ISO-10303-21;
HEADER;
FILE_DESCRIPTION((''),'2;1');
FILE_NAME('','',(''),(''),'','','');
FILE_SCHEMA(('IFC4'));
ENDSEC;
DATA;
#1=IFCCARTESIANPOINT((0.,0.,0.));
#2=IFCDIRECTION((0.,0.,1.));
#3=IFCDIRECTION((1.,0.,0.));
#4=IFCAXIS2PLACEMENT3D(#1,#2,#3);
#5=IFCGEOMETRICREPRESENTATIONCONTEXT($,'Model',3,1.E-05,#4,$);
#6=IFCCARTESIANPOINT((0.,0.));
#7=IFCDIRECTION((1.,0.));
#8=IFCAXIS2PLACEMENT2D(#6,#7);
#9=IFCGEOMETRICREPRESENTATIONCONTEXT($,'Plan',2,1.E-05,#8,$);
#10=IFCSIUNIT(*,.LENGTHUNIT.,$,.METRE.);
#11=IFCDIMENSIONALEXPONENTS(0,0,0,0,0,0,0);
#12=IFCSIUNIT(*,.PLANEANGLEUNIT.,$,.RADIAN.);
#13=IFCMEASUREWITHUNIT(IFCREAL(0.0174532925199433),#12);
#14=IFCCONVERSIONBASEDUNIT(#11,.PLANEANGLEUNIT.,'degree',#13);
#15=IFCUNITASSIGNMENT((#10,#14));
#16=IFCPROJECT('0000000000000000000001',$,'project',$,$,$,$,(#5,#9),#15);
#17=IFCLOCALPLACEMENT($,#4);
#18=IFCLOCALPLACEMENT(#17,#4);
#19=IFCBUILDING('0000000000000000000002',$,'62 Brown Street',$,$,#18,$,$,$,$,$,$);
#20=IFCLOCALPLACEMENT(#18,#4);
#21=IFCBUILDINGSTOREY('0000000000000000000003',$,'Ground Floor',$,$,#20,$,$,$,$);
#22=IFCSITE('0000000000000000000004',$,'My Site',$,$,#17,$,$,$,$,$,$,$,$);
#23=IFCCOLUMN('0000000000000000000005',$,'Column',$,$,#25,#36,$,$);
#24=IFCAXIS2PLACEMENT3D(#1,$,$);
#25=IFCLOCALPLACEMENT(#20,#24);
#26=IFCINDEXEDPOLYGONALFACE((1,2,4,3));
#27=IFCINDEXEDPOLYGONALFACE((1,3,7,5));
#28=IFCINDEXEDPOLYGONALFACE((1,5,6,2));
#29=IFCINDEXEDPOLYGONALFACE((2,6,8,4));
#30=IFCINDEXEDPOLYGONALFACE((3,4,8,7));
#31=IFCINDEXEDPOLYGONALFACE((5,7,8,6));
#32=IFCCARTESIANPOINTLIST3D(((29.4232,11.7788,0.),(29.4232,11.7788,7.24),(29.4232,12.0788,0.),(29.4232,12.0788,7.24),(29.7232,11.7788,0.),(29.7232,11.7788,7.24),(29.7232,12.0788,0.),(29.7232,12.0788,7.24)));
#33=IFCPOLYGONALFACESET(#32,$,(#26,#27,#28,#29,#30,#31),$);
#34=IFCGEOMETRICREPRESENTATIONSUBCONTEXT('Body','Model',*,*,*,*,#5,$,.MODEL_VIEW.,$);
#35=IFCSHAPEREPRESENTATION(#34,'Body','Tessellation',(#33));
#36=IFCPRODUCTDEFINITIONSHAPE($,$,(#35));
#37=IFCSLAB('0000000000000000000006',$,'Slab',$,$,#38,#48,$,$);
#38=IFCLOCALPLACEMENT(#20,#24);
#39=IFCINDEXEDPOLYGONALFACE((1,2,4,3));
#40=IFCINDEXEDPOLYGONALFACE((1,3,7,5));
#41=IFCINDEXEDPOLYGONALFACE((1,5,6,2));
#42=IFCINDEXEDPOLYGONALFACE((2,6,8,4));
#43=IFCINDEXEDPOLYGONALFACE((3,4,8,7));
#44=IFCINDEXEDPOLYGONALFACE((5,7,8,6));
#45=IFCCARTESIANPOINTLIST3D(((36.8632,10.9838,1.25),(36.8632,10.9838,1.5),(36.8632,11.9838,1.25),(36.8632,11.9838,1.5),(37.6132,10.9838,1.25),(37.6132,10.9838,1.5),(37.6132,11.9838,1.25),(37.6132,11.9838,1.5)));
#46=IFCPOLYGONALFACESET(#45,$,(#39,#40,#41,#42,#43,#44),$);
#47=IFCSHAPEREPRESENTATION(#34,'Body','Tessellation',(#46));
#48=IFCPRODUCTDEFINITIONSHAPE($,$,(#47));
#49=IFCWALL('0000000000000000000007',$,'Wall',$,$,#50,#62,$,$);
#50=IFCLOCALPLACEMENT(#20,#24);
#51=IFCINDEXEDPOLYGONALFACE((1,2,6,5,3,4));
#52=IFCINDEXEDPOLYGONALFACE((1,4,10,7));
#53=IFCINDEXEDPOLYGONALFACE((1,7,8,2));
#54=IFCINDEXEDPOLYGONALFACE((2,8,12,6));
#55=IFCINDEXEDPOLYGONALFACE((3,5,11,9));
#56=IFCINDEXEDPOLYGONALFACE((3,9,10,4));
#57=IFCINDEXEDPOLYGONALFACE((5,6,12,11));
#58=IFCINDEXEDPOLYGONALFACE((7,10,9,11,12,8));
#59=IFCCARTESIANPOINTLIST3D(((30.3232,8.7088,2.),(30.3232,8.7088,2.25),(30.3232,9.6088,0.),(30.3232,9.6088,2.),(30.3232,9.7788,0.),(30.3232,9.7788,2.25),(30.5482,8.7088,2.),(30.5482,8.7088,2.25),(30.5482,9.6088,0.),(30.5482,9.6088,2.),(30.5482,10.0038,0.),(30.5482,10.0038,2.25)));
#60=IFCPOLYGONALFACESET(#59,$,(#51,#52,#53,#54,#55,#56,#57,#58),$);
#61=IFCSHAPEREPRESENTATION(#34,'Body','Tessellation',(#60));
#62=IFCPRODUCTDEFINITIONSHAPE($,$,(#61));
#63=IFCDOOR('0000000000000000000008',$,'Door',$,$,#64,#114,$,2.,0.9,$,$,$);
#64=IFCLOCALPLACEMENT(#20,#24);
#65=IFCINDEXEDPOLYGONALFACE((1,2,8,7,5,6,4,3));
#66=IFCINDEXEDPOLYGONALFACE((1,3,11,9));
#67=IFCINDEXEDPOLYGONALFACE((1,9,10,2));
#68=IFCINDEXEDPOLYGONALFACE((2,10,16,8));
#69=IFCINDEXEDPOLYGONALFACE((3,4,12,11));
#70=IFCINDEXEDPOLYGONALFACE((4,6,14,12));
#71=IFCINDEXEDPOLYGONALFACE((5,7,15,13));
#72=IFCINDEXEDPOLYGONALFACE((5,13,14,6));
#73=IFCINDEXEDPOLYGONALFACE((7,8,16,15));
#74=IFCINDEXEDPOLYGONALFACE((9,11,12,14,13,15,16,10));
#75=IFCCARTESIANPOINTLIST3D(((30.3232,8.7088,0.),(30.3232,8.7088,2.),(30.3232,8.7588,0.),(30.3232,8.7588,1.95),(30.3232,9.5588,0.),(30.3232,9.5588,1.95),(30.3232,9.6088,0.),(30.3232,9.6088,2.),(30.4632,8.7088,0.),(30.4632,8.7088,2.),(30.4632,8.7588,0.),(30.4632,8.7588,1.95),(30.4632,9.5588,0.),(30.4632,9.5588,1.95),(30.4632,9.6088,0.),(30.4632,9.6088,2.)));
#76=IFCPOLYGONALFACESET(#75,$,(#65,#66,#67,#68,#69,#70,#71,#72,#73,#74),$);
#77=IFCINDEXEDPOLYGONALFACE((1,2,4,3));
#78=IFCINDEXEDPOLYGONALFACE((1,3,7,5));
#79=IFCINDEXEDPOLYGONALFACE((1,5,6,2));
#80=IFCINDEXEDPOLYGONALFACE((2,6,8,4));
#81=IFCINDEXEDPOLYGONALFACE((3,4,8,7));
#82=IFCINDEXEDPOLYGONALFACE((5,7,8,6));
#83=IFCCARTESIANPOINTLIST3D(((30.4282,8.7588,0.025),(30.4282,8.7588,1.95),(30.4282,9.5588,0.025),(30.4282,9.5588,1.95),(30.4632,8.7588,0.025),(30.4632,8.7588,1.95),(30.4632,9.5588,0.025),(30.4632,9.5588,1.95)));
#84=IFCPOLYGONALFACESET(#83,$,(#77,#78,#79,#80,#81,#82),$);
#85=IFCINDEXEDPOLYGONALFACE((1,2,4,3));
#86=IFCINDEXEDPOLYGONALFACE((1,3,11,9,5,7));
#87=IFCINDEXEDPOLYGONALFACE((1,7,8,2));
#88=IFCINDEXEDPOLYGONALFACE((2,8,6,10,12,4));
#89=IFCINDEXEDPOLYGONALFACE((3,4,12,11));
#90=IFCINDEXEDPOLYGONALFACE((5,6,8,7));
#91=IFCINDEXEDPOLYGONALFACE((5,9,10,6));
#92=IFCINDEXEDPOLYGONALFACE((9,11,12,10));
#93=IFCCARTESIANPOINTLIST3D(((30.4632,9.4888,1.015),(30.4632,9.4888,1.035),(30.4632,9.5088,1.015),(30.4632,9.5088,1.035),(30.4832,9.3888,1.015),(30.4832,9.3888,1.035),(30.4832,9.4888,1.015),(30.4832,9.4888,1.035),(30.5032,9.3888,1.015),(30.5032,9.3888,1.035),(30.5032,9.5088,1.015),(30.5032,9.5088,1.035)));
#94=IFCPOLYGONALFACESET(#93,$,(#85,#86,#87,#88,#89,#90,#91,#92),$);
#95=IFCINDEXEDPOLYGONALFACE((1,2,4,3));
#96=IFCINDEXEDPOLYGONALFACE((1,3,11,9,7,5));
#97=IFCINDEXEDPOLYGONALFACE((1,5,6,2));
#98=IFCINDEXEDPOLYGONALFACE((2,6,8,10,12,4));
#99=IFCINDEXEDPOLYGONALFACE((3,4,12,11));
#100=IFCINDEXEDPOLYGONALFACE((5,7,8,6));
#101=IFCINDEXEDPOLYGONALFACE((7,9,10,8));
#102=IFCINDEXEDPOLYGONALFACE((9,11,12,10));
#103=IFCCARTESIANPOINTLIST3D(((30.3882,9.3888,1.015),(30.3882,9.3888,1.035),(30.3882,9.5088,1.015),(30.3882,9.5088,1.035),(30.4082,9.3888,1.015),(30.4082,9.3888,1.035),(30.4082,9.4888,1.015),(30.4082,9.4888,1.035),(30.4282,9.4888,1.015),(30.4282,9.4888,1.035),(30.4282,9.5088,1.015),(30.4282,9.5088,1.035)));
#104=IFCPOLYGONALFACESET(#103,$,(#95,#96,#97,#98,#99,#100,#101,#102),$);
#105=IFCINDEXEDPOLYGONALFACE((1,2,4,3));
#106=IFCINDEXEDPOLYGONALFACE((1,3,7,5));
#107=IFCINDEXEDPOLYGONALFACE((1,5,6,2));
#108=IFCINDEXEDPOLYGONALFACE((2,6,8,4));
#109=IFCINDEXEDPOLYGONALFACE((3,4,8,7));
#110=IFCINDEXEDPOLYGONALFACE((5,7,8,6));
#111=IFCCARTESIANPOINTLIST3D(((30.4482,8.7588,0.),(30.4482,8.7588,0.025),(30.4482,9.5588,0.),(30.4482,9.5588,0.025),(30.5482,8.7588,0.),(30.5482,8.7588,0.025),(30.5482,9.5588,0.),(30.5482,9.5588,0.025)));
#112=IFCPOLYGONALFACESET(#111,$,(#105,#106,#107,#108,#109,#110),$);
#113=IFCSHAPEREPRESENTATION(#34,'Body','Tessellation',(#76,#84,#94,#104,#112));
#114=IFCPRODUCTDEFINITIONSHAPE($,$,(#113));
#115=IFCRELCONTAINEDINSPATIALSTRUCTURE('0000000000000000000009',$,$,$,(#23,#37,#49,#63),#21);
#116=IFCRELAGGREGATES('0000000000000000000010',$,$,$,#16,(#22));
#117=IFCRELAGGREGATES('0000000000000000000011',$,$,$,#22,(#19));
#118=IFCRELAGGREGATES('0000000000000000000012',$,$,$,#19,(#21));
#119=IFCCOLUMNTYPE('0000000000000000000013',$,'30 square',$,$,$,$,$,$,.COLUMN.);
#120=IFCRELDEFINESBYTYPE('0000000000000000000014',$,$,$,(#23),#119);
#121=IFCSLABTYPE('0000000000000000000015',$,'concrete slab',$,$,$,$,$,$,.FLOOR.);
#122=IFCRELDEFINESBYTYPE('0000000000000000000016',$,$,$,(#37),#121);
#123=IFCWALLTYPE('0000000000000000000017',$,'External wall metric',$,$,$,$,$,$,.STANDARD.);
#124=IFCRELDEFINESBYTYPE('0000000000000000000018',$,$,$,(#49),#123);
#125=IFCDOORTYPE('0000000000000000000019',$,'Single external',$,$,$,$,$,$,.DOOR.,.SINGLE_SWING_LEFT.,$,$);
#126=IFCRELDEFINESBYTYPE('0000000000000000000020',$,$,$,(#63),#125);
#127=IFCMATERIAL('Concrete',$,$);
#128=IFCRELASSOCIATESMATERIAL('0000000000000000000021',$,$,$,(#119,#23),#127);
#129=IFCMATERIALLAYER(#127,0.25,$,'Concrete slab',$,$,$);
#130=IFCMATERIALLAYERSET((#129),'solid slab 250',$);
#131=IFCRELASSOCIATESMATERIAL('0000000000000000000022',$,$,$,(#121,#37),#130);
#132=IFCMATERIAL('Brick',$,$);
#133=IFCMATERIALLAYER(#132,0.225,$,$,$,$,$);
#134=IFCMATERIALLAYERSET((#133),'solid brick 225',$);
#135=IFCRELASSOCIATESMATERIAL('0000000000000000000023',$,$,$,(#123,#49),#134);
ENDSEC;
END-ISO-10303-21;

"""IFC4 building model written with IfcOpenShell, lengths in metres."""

from ifc_helpers import new_model, entity, si_unit, converted_unit, frame, origin_with_axes, origin_2d_with_axis, place, context, subcontext, project, spatial, line, indexed_curve, rectangle, outline, extrude, clip, halfspace, shape, source, transform, mapped, material, layer, layer_set, layer_usage, material_profile, profile_set, profile_usage, type_object, type_shapes, element, fill, save


model = new_model("IFC4")

# Units and contexts
model_context = context("Model", 3, precision=1e-05, world=origin_with_axes())
plan_context = context("Plan", 2, precision=1e-05, world=origin_2d_with_axis())
body_context_1 = subcontext(model_context, "Body", "Model", "MODEL_VIEW")
body_context_2 = subcontext(plan_context, "Body", "Plan", "PLAN_VIEW")
ifc_project = project(units=[si_unit("LENGTHUNIT", "METRE"), converted_unit("PLANEANGLEUNIT", "degree", entity("IfcReal", 0.0174532925199433), si_unit("PLANEANGLEUNIT", "RADIAN"), dimensions=[0, 0, 0, 0, 0, 0, 0])], contexts=[model_context, plan_context])

# Site, building, storey
site_placement = place(None, origin_with_axes())
site = spatial("IfcSite", under=ifc_project, at=site_placement, Name="My Site")
building_placement = place(site_placement, origin_with_axes())
building = spatial("IfcBuilding", under=site, at=building_placement, Name="62 Brown Street")
storey_placement = place(building_placement, origin_with_axes())
storey = spatial("IfcBuildingStorey", under=building, at=storey_placement, Name="Ground Floor")

# Column
ifc_material_1 = material(Name="Concrete")
ifc_material_profile = material_profile(ifc_material_1, rectangle(XDim=0.3, YDim=0.3))
ifc_profile_set = profile_set([ifc_material_profile])
ifc_profile_usage = profile_usage(ifc_profile_set, cardinal=5)
column_type = type_object("IfcColumnType", Name="30 square", PredefinedType="COLUMN", material=ifc_profile_set)
column_placement = place(storey_placement, frame((29.5732, 11.9288, 0.0), z_axis=(0.0, 0.0, 1.0), x_axis=(1.0, 0.0, 0.0)))
element("IfcColumn", 1, at=column_placement, inside=storey, type_object=column_type, material=ifc_profile_usage, Name="Column", context=body_context_1, shape_type="SweptSolid", body=[
    extrude(rectangle(XDim=0.3, YDim=0.3), origin_with_axes(), (0.0, 0.0, 1.0), 7.24),
])

# Slab
ifc_layer_1 = layer(ifc_material_1, 0.25, Name="Concrete slab")
ifc_layer_set_1 = layer_set([ifc_layer_1], Name="solid slab 250")
slab_type = type_object("IfcSlabType", Name="concrete slab", PredefinedType="FLOOR", material=ifc_layer_set_1)
ifc_layer_usage_1 = layer_usage(ifc_layer_set_1, "AXIS3", "POSITIVE", 0.0)
slab_1_placement = place(storey_placement, frame((36.8632, 10.9838, 1.25), z_axis=(0.0, 0.0, 1.0), x_axis=(1.0, 0.0, 0.0)))
element("IfcSlab", 2, at=slab_1_placement, inside=storey, type_object=slab_type, material=ifc_layer_usage_1, Name="Slab", context=body_context_1, shape_type="SweptSolid", body=[
    extrude(outline(indexed_curve([(0.0, 0.0), (0.75, 0.0), (0.75, 1.0), (0.0, 1.0)], segments=[line(4, 1), line(1, 2), line(2, 3), line(3, 4)], self_intersect=False)), None, (0.0, 0.0, 1.0), 0.25),
])

# Shared definitions
ifc_material_2 = material(Name="Brick")
ifc_layer_2 = layer(ifc_material_2, 0.225)
ifc_layer_set_2 = layer_set([ifc_layer_2], Name="solid brick 225")
wall_type_1 = type_object("IfcWallType", Name="External wall metric", PredefinedType="STANDARD", material=ifc_layer_set_2)

# Wall, opening, door
ifc_layer_usage_2 = layer_usage(ifc_layer_set_2, "AXIS2", "POSITIVE", 0.0)
wall_1_placement = place(storey_placement, frame((30.5482, 8.7088, 0.0), z_axis=(0.0, 0.0, 1.0), x_axis=(0.0, 1.0, 0.0)))
wall_1 = element("IfcWall", 3, at=wall_1_placement, inside=storey, type_object=wall_type_1, material=ifc_layer_usage_2, Name="Wall", context=body_context_1, shape_type="Clipping", body=[
    clip(extrude(outline(indexed_curve([(0.0, 0.0), (0.0, 0.225), (1.295, 0.225), (1.295, 0.0), (0.0, 0.0)], self_intersect=False)), origin_with_axes(), (0.0, 0.0, 1.0), 2.25), halfspace(frame((1.295, 0.0, 0.0), z_axis=(0.506251, 0.506251, 0.0), x_axis=(-0.225, 0.225, 0.0)), False)),
])
shared_shape_1 = source(origin_with_axes(), body_context_1, "Body", "SweptSolid", [
    extrude(outline(indexed_curve([(0.0, 0.0), (0.9, 0.0), (0.9, 2.0), (0.0, 2.0)], segments=[line(1, 2, 3, 4, 1)])), frame((0.0, -0.6, 0.0), z_axis=(0.0, -1.0, 0.0), x_axis=(1.0, 0.0, 0.0)), (0.0, 0.0, -1.0), 1.2),
])
opening_1_placement = place(wall_1_placement, frame((0.0, 0.0, 0.0), z_axis=(0.0, 0.0, 1.0), x_axis=(1.0, 0.0, 0.0)))
opening_1 = element("IfcOpeningElement", 4, at=opening_1_placement, cuts=wall_1, PredefinedType="OPENING", context=body_context_1, shape_type="MappedRepresentation", body=[
    mapped(shared_shape_1, transform((0.0, 0.0, 0.0), x_axis=(1.0, 0.0, 0.0), y_axis=(0.0, 1.0, 0.0), z_axis=(0.0, 0.0, 1.0), scale=1.0)),
])
door_type_1 = type_object("IfcDoorType", Name="Single external", OperationType="SINGLE_SWING_LEFT", PredefinedType="DOOR")
shared_shape_2 = source(origin_with_axes(), body_context_1, "Body", "SweptSolid", [
    extrude(outline(indexed_curve([(0.0, 0.0), (0.0, 2.0), (0.9, 2.0), (0.9, 0.0), (0.85, 0.0), (0.85, 1.95), (0.05, 1.95), (0.05, 0.0)], segments=[line(1, 2, 3, 4, 5, 6, 7, 8, 1)])), frame((0.0, 0.085, 0.0), z_axis=(0.0, -1.0, 0.0), x_axis=(1.0, 0.0, 0.0)), (0.0, 0.0, -1.0), 0.14),
    extrude(outline(indexed_curve([(0.0, 0.0), (0.8, 0.0), (0.8, 0.035), (0.0, 0.035)], segments=[line(1, 2, 3, 4, 1)])), frame((0.05, 0.085, 0.025), z_axis=(0.0, 0.0, 1.0), x_axis=(1.0, 0.0, 0.0)), (0.0, 0.0, 1.0), 1.925),
    extrude(outline(indexed_curve([(0.0, 0.0), (0.0, -0.04), (-0.12, -0.04), (-0.12, -0.02), (-0.02, -0.02), (-0.02, 0.0)], segments=[line(1, 2, 3, 4, 5, 6, 1)])), frame((0.8, 0.085, 1.015), z_axis=(0.0, 0.0, 1.0), x_axis=(1.0, 0.0, 0.0)), (0.0, 0.0, 1.0), 0.02),
    extrude(outline(indexed_curve([(0.0, 0.0), (0.0, 0.04), (-0.12, 0.04), (-0.12, 0.02), (-0.02, 0.02), (-0.02, 0.0)], segments=[line(1, 2, 3, 4, 5, 6, 1)])), frame((0.8, 0.12, 1.015), z_axis=(0.0, 0.0, 1.0), x_axis=(1.0, 0.0, 0.0)), (0.0, 0.0, 1.0), 0.02),
    extrude(outline(indexed_curve([(0.0, 0.0), (0.8, 0.0), (0.8, 0.1), (0.0, 0.1)], segments=[line(1, 2, 3, 4, 1)])), frame((0.05, 0.0, 0.0), z_axis=(0.0, 0.0, 1.0), x_axis=(1.0, 0.0, 0.0)), (0.0, 0.0, 1.0), 0.025),
])
shared_shape_3 = source(origin_with_axes(), body_context_2, "Body", "Curve2D", [
    entity("IfcIndexedPolyCurve", entity("IfcCartesianPointList2D", [[0.0, 0.085], [0.05, 0.085], [0.05, 0.225], [0.0, 0.225]]), [entity("IfcLineIndex", [1, 2, 3, 4, 1])]),
    entity("IfcIndexedPolyCurve", entity("IfcCartesianPointList2D", [[0.9, 0.085], [0.85, 0.085], [0.85, 0.225], [0.9, 0.225]]), [entity("IfcLineIndex", [1, 2, 3, 4, 1])]),
    entity("IfcTrimmedCurve", entity("IfcEllipse", entity("IfcAxis2Placement2D", entity("IfcCartesianPoint", [0.085, 0.225]), entity("IfcDirection", [1.0, 0.0])), 0.765, 0.8), [entity("IfcCartesianPoint", [0.85, 0.225])], [entity("IfcCartesianPoint", [0.085, 1.025])], True, "CARTESIAN"),
    entity("IfcIndexedPolyCurve", entity("IfcCartesianPointList2D", [[0.05, 0.225], [0.085, 0.225], [0.085, 1.025], [0.05, 1.025]]), [entity("IfcLineIndex", [1, 2, 3, 4, 1])]),
])
type_shapes(door_type_1, [shared_shape_2, shared_shape_3])
door_1_placement = place(opening_1_placement, frame((0.0, 0.0, 0.0), z_axis=(0.0, 0.0, 1.0), x_axis=(1.0, 0.0, 0.0)))
door_1 = element("IfcDoor", 5, at=door_1_placement, inside=storey, type_object=door_type_1, Name="Door", OverallHeight=2.0, OverallWidth=0.9, shapes=[
    shape(body_context_1, "Body", "MappedRepresentation", [mapped(shared_shape_2, transform((0.0, 0.0, 0.0), x_axis=(1.0, 0.0, 0.0), y_axis=(0.0, 1.0, 0.0), z_axis=(0.0, 0.0, 1.0), scale=1.0))]),
    shape(body_context_2, "Body", "MappedRepresentation", [mapped(shared_shape_3, transform((0.0, 0.0, 0.0), x_axis=(1.0, 0.0, 0.0), y_axis=(0.0, 1.0, 0.0), z_axis=(0.0, 0.0, 1.0), scale=1.0))]),
])
fill(opening_1, door_1)

save(model, "model.ifc")
